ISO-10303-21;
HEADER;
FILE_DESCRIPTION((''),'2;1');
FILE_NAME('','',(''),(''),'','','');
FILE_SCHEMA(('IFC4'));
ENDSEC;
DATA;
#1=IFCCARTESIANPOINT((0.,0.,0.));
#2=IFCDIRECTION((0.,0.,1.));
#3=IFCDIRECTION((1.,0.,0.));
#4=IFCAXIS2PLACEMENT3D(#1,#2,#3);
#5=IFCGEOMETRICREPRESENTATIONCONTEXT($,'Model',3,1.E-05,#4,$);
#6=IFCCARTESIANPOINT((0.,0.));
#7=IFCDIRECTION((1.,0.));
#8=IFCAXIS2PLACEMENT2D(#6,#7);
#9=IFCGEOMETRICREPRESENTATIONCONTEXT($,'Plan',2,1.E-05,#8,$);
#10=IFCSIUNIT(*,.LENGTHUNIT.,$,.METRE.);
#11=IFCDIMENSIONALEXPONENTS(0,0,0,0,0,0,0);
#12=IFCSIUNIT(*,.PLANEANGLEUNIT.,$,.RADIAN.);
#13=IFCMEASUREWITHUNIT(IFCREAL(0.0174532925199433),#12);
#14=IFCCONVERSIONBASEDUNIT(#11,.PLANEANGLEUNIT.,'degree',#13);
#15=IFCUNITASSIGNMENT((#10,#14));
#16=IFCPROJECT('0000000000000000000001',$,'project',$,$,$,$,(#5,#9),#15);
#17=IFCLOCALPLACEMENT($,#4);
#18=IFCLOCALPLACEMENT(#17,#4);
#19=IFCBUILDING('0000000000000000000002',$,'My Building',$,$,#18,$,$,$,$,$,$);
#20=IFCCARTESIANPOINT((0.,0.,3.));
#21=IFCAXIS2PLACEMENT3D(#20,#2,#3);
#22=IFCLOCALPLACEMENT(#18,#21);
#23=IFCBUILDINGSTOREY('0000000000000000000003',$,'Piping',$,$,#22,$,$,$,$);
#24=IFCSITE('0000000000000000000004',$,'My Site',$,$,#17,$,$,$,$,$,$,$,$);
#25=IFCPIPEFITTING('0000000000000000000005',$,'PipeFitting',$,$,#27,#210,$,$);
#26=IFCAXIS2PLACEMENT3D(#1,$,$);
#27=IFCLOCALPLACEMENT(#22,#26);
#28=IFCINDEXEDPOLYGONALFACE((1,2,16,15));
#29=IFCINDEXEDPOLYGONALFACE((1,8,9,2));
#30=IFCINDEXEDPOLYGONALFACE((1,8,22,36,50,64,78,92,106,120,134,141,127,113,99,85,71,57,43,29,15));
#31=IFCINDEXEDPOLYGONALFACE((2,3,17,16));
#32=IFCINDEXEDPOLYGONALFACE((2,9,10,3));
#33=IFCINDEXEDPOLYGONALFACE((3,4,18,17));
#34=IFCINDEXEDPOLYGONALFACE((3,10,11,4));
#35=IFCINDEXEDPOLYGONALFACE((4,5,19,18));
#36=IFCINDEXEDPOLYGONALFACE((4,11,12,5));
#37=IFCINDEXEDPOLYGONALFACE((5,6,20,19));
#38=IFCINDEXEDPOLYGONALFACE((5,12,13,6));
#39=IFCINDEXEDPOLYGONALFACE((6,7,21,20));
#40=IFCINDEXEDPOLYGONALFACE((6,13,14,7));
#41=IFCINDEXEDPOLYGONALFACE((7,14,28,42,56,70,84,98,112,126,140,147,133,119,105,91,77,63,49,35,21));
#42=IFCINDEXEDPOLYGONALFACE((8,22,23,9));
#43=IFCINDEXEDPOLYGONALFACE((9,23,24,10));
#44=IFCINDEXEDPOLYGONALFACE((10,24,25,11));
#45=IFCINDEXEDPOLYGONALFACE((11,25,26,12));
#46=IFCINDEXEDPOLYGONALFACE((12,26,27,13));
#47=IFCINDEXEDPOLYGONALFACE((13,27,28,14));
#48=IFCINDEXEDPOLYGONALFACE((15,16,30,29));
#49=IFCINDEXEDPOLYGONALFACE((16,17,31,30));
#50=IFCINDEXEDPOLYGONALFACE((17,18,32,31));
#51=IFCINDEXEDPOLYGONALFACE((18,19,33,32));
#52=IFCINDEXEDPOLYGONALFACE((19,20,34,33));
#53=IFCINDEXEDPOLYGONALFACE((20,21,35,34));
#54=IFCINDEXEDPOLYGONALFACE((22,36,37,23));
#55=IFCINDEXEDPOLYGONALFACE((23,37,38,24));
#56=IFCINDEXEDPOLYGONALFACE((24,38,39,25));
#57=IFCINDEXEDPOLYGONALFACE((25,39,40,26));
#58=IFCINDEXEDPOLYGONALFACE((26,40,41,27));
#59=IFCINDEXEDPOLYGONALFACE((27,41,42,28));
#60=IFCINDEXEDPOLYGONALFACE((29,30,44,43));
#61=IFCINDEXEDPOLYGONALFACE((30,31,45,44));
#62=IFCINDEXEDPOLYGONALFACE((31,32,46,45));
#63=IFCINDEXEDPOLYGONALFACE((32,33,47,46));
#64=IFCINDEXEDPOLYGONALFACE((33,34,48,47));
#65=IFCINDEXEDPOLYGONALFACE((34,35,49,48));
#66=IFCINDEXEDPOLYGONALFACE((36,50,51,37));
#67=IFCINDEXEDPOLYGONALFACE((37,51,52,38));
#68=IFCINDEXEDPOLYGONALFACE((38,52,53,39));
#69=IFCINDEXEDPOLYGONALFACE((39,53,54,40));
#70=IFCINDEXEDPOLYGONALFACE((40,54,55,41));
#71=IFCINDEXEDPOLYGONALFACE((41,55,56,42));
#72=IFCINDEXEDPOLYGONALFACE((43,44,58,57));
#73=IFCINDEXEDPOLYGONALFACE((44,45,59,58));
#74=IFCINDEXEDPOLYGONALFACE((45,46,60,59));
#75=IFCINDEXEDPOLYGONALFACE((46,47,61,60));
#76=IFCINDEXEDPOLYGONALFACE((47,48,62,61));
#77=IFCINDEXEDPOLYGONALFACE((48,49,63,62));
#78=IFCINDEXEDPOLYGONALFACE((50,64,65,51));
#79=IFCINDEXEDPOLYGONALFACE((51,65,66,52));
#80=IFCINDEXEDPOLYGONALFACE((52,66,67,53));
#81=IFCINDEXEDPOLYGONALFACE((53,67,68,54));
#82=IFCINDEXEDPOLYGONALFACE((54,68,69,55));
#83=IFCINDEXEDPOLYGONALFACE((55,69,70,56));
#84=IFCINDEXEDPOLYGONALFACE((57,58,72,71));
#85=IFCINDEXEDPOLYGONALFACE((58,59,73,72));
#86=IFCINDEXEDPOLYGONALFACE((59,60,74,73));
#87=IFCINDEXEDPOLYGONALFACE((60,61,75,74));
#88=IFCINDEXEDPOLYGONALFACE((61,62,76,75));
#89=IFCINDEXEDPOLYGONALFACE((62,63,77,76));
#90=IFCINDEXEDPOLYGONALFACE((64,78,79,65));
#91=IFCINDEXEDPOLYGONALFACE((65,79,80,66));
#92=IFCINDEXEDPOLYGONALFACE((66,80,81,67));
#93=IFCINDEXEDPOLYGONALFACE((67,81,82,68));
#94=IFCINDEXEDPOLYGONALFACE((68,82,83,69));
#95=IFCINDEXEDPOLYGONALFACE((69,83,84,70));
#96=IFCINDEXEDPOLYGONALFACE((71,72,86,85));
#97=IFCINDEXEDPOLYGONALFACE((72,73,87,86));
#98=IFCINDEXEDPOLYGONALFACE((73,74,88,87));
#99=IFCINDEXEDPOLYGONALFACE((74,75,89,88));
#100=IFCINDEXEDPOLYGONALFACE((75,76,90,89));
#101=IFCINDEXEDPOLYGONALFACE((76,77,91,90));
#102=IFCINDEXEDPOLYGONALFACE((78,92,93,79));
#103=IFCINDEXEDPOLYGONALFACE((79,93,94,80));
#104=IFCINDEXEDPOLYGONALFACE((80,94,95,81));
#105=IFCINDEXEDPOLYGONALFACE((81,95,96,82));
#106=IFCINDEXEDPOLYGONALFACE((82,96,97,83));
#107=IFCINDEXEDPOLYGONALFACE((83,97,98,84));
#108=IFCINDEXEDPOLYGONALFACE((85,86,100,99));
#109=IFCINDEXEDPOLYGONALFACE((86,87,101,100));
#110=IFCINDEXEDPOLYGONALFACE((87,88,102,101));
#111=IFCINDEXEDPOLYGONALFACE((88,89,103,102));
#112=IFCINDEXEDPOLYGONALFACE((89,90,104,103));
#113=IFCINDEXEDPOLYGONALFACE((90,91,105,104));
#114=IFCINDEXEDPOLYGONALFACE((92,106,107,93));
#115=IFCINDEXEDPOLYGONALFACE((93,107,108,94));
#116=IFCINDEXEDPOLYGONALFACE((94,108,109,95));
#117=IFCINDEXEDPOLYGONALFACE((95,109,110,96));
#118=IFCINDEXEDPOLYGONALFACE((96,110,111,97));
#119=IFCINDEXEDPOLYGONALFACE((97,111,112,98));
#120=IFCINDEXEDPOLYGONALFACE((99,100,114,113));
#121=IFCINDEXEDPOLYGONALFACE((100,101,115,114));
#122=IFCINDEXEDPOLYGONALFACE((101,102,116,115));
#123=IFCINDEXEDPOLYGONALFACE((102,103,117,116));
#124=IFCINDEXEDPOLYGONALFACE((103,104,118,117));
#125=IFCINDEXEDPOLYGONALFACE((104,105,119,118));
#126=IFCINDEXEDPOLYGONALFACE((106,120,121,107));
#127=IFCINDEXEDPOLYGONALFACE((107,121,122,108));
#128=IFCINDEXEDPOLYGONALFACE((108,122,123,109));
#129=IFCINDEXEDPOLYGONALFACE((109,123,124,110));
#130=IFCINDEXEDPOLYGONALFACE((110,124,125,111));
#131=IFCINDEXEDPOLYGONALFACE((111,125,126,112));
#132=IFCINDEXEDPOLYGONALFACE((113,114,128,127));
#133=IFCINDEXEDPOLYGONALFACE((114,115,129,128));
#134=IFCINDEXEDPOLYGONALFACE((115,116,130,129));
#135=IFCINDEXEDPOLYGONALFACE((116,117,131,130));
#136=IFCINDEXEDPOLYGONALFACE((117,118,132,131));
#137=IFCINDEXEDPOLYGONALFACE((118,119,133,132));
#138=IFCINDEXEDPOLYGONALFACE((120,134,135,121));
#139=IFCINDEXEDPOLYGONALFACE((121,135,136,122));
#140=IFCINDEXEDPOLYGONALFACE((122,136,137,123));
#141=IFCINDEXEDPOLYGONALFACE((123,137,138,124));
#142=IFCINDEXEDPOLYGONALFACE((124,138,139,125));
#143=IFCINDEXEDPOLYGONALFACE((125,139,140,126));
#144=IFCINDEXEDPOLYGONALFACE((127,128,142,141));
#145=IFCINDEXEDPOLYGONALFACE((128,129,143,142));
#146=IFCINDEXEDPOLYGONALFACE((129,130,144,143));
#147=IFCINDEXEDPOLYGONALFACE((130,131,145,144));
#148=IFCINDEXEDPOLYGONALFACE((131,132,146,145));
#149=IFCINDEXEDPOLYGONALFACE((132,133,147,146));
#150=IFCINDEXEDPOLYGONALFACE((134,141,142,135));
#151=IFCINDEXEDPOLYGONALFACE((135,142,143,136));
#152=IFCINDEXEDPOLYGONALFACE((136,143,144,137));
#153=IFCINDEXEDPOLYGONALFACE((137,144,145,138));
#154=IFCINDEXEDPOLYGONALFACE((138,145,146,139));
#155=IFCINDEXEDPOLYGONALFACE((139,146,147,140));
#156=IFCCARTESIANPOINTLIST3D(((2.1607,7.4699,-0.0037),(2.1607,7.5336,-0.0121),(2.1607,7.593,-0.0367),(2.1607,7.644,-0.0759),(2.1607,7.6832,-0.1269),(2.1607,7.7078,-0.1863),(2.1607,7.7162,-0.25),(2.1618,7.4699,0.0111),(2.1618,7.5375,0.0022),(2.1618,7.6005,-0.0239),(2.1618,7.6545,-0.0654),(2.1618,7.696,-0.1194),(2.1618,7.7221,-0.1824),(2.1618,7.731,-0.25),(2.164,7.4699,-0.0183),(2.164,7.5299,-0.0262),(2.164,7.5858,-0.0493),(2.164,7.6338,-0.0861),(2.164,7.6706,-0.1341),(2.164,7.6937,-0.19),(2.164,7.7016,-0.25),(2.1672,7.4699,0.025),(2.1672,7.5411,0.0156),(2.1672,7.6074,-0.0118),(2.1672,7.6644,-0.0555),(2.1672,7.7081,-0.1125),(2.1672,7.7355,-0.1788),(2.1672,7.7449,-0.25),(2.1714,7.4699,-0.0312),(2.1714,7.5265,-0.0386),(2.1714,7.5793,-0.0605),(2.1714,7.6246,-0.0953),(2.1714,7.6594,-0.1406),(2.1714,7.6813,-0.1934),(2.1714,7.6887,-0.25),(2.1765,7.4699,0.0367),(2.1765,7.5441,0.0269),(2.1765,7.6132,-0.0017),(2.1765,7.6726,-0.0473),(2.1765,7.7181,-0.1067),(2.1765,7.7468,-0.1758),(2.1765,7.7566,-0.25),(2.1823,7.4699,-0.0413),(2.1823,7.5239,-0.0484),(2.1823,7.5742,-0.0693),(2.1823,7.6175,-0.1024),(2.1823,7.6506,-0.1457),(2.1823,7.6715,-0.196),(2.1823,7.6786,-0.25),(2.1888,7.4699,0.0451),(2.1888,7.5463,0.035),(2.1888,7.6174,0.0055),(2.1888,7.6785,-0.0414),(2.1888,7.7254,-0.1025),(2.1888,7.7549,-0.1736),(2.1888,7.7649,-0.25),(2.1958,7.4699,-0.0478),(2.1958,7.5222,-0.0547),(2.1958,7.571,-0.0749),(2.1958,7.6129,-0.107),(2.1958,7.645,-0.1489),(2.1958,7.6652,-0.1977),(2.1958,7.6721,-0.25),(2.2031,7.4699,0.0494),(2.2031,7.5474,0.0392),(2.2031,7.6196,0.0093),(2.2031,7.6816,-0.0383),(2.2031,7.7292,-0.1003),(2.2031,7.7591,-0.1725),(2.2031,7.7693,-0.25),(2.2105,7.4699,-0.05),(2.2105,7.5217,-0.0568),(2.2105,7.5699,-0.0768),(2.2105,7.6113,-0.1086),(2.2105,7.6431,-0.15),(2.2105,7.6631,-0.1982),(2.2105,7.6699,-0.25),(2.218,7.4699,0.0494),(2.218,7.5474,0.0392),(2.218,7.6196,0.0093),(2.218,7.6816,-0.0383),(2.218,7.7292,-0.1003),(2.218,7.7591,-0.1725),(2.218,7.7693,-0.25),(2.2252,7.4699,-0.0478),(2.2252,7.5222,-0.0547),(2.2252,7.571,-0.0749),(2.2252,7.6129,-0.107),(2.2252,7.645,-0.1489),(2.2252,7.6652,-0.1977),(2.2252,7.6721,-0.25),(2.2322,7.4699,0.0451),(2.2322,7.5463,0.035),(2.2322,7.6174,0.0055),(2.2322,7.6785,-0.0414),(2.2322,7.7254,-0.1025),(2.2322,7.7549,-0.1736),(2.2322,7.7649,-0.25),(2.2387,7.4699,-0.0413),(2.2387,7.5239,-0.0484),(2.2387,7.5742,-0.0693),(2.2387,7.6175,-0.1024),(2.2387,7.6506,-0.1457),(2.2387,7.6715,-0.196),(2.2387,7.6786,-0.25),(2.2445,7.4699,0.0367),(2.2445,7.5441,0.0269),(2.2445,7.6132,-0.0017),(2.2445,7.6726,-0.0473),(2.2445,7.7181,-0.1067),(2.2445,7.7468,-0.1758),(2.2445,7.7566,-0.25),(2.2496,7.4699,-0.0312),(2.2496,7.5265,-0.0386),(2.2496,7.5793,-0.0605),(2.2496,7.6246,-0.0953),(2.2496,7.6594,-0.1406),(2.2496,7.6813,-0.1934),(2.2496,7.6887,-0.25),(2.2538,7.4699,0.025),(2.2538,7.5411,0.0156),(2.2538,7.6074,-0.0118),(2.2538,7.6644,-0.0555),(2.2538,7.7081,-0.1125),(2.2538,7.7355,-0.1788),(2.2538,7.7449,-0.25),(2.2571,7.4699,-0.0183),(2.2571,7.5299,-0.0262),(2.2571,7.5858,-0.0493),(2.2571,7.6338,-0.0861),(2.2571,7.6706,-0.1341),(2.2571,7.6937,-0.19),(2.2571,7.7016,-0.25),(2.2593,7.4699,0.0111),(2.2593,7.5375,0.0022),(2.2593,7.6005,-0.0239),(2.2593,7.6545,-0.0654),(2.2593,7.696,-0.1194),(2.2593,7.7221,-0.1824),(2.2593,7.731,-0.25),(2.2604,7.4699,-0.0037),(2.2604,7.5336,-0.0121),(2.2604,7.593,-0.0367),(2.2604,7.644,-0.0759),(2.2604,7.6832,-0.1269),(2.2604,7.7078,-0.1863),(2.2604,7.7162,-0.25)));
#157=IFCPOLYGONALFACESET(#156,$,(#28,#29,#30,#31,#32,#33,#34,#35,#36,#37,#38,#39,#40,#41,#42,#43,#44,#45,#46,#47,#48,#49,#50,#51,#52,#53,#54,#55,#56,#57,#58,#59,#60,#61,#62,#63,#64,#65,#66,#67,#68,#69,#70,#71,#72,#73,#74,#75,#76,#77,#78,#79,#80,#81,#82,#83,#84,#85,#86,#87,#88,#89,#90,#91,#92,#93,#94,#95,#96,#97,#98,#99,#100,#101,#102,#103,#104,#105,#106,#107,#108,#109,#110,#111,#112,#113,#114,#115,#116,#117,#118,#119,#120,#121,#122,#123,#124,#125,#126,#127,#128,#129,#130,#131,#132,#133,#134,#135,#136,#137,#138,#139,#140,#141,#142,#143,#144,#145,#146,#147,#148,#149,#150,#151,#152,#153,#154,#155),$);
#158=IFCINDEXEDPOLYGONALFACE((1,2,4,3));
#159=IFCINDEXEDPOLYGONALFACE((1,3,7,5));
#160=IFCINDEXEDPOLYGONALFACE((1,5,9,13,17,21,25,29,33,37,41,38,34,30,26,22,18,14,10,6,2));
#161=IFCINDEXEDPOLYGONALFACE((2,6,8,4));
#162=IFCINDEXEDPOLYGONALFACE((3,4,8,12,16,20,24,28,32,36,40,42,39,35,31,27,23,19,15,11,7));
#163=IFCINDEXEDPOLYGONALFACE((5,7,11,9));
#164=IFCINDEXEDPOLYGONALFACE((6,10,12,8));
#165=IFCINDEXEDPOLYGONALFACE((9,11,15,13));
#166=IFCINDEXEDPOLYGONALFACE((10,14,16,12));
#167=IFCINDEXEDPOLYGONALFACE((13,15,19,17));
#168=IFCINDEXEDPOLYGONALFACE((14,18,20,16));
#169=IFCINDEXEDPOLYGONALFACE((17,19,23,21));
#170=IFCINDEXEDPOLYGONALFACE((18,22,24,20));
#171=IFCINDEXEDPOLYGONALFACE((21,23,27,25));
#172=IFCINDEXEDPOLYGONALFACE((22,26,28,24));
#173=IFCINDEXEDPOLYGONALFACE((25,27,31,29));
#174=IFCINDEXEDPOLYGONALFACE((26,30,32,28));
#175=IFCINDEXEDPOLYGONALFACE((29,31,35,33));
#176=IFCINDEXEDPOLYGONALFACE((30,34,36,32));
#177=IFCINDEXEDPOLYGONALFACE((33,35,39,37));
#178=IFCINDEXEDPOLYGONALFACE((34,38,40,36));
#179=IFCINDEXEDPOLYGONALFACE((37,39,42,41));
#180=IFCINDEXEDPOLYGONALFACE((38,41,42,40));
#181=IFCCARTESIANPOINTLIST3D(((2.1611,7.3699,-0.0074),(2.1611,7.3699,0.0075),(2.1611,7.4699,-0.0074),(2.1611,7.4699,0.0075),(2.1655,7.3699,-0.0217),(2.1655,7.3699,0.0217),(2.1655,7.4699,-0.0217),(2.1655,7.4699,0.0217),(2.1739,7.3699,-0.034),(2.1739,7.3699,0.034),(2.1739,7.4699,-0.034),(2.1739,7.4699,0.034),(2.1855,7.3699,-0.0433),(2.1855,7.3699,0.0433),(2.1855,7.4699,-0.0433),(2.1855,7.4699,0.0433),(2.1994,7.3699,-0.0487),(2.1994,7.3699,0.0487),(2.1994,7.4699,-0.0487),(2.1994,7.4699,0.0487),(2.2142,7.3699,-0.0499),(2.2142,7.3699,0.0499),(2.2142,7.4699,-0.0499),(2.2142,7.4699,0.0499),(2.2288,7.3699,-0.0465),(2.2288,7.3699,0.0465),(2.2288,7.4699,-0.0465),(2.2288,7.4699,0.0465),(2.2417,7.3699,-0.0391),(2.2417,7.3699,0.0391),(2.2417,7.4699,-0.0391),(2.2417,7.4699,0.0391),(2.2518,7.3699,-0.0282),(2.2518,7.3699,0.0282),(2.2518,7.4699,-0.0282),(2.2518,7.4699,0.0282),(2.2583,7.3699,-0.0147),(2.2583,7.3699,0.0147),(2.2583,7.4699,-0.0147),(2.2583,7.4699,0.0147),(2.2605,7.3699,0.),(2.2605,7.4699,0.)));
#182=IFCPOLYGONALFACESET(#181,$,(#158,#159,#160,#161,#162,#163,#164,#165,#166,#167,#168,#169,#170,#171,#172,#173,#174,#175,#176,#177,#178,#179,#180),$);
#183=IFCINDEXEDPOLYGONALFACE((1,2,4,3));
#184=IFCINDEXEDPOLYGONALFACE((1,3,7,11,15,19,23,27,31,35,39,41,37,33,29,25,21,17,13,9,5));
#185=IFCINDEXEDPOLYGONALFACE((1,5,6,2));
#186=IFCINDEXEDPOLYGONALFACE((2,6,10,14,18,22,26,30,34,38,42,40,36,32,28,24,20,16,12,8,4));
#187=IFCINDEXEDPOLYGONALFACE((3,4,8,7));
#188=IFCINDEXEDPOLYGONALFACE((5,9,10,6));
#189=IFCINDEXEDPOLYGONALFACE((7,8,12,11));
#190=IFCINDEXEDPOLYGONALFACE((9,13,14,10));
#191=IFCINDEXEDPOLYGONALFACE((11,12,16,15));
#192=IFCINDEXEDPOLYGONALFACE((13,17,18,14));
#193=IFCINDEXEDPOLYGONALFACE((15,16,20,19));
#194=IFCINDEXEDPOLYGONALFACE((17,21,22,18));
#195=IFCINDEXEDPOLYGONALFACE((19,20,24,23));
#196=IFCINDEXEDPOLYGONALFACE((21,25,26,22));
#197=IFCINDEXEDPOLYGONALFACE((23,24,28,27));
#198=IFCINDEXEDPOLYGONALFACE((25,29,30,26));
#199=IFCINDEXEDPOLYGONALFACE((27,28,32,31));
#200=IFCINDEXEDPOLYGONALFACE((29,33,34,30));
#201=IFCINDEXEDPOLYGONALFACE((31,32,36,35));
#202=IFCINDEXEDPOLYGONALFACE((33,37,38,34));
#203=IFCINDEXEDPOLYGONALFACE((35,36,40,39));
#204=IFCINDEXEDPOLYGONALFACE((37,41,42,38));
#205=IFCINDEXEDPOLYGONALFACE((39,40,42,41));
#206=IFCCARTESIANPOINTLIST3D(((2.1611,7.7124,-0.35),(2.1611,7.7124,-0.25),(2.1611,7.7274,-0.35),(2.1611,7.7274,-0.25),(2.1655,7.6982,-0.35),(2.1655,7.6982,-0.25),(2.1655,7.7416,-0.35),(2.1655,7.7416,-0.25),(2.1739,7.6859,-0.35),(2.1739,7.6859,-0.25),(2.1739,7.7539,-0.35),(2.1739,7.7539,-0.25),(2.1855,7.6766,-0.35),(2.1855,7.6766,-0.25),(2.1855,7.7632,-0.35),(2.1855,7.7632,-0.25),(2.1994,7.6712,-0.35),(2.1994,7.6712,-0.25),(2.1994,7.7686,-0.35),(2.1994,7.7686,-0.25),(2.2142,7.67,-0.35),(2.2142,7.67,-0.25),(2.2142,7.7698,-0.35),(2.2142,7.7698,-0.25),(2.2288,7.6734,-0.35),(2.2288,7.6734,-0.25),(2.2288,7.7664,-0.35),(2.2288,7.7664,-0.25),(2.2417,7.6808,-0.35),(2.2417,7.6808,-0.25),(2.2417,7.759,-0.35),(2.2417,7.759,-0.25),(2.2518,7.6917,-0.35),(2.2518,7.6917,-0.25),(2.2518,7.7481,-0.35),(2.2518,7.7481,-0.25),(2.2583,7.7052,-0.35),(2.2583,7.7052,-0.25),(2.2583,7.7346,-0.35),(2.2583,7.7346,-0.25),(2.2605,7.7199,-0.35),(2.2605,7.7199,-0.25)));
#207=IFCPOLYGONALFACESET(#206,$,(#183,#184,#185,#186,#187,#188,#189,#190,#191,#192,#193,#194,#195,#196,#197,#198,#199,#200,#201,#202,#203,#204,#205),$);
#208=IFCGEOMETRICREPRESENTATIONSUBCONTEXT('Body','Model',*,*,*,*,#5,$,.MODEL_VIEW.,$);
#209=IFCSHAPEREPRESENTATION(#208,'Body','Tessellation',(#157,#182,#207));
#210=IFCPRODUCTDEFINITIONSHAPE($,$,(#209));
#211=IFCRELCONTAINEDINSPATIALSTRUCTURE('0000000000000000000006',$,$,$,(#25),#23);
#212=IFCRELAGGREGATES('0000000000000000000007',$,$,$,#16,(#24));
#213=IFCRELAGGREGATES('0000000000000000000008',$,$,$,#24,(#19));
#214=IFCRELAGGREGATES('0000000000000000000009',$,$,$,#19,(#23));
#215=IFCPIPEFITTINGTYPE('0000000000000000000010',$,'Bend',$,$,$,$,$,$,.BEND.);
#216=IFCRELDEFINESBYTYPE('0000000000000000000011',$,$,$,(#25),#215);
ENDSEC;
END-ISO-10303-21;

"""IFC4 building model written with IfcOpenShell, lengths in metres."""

from ifc_helpers import new_model, entity, si_unit, converted_unit, frame, origin_with_axes, origin_2d_with_axis, place, context, subcontext, project, spatial, circle, extrude, source, transform, mapped, type_object, type_shapes, element, save


model = new_model("IFC4")

# Units and contexts
model_context = context("Model", 3, precision=1e-05, world=origin_with_axes())
plan_context = context("Plan", 2, precision=1e-05, world=origin_2d_with_axis())
body_context = subcontext(model_context, "Body", "Model", "MODEL_VIEW")
ifc_project = project(units=[si_unit("LENGTHUNIT", "METRE"), converted_unit("PLANEANGLEUNIT", "degree", entity("IfcReal", 0.0174532925199433), si_unit("PLANEANGLEUNIT", "RADIAN"), dimensions=[0, 0, 0, 0, 0, 0, 0])], contexts=[model_context, plan_context])

# Site, building, storey
site_placement = place(None, origin_with_axes())
site = spatial("IfcSite", under=ifc_project, at=site_placement, Name="My Site")
building_placement = place(site_placement, origin_with_axes())
building = spatial("IfcBuilding", under=site, at=building_placement, Name="My Building")
storey_placement = place(building_placement, frame((0.0, 0.0, 3.0), z_axis=(0.0, 0.0, 1.0), x_axis=(1.0, 0.0, 0.0)))
storey = spatial("IfcBuildingStorey", under=building, at=storey_placement, Name="Piping")

# Pipe fitting
pipe_fitting_type = type_object("IfcPipeFittingType", Name="Bend", PredefinedType="BEND")
shared_shape = source(origin_with_axes(), body_context, "Body", "SolidModel", [
    entity("IfcSweptDiskSolid", entity("IfcIndexedPolyCurve", entity("IfcCartesianPointList3D", [[0.0, 0.0, -0.1], [0.0, -0.0732, -0.2768], [0.0, -0.25, -0.35]]), [entity("IfcArcIndex", [1, 2, 3])]), 0.05),
    extrude(circle(Radius=0.05), origin_with_axes(), (0.0, 0.0, -1.0), 0.1),
    extrude(circle(Radius=0.05), frame((0.0, -0.25, -0.35), z_axis=(0.0, -1.0, 0.0), x_axis=(1.0, 0.0, 0.0)), (0.0, 0.0, 1.0), 0.1),
])
type_shapes(pipe_fitting_type, [shared_shape])
for number, where, z_axis, x_axis, name in (
    (1, (2.2105, 7.3699, 0.0), (0.0, -1.0, 0.0), (1.0, 0.0, 0.0), "PipeFitting"),
):
    element("IfcPipeFitting", number, at=place(storey_placement, frame(where, z_axis=z_axis, x_axis=x_axis)), inside=storey, type_object=pipe_fitting_type, Name=name, context=body_context, shape_type="MappedRepresentation", body=[
        mapped(shared_shape, transform((0.0, 0.0, 0.0), x_axis=(1.0, 0.0, 0.0), y_axis=(0.0, 1.0, 0.0), z_axis=(0.0, 0.0, 1.0), scale=1.0)),
    ])

save(model, "model.ifc")
